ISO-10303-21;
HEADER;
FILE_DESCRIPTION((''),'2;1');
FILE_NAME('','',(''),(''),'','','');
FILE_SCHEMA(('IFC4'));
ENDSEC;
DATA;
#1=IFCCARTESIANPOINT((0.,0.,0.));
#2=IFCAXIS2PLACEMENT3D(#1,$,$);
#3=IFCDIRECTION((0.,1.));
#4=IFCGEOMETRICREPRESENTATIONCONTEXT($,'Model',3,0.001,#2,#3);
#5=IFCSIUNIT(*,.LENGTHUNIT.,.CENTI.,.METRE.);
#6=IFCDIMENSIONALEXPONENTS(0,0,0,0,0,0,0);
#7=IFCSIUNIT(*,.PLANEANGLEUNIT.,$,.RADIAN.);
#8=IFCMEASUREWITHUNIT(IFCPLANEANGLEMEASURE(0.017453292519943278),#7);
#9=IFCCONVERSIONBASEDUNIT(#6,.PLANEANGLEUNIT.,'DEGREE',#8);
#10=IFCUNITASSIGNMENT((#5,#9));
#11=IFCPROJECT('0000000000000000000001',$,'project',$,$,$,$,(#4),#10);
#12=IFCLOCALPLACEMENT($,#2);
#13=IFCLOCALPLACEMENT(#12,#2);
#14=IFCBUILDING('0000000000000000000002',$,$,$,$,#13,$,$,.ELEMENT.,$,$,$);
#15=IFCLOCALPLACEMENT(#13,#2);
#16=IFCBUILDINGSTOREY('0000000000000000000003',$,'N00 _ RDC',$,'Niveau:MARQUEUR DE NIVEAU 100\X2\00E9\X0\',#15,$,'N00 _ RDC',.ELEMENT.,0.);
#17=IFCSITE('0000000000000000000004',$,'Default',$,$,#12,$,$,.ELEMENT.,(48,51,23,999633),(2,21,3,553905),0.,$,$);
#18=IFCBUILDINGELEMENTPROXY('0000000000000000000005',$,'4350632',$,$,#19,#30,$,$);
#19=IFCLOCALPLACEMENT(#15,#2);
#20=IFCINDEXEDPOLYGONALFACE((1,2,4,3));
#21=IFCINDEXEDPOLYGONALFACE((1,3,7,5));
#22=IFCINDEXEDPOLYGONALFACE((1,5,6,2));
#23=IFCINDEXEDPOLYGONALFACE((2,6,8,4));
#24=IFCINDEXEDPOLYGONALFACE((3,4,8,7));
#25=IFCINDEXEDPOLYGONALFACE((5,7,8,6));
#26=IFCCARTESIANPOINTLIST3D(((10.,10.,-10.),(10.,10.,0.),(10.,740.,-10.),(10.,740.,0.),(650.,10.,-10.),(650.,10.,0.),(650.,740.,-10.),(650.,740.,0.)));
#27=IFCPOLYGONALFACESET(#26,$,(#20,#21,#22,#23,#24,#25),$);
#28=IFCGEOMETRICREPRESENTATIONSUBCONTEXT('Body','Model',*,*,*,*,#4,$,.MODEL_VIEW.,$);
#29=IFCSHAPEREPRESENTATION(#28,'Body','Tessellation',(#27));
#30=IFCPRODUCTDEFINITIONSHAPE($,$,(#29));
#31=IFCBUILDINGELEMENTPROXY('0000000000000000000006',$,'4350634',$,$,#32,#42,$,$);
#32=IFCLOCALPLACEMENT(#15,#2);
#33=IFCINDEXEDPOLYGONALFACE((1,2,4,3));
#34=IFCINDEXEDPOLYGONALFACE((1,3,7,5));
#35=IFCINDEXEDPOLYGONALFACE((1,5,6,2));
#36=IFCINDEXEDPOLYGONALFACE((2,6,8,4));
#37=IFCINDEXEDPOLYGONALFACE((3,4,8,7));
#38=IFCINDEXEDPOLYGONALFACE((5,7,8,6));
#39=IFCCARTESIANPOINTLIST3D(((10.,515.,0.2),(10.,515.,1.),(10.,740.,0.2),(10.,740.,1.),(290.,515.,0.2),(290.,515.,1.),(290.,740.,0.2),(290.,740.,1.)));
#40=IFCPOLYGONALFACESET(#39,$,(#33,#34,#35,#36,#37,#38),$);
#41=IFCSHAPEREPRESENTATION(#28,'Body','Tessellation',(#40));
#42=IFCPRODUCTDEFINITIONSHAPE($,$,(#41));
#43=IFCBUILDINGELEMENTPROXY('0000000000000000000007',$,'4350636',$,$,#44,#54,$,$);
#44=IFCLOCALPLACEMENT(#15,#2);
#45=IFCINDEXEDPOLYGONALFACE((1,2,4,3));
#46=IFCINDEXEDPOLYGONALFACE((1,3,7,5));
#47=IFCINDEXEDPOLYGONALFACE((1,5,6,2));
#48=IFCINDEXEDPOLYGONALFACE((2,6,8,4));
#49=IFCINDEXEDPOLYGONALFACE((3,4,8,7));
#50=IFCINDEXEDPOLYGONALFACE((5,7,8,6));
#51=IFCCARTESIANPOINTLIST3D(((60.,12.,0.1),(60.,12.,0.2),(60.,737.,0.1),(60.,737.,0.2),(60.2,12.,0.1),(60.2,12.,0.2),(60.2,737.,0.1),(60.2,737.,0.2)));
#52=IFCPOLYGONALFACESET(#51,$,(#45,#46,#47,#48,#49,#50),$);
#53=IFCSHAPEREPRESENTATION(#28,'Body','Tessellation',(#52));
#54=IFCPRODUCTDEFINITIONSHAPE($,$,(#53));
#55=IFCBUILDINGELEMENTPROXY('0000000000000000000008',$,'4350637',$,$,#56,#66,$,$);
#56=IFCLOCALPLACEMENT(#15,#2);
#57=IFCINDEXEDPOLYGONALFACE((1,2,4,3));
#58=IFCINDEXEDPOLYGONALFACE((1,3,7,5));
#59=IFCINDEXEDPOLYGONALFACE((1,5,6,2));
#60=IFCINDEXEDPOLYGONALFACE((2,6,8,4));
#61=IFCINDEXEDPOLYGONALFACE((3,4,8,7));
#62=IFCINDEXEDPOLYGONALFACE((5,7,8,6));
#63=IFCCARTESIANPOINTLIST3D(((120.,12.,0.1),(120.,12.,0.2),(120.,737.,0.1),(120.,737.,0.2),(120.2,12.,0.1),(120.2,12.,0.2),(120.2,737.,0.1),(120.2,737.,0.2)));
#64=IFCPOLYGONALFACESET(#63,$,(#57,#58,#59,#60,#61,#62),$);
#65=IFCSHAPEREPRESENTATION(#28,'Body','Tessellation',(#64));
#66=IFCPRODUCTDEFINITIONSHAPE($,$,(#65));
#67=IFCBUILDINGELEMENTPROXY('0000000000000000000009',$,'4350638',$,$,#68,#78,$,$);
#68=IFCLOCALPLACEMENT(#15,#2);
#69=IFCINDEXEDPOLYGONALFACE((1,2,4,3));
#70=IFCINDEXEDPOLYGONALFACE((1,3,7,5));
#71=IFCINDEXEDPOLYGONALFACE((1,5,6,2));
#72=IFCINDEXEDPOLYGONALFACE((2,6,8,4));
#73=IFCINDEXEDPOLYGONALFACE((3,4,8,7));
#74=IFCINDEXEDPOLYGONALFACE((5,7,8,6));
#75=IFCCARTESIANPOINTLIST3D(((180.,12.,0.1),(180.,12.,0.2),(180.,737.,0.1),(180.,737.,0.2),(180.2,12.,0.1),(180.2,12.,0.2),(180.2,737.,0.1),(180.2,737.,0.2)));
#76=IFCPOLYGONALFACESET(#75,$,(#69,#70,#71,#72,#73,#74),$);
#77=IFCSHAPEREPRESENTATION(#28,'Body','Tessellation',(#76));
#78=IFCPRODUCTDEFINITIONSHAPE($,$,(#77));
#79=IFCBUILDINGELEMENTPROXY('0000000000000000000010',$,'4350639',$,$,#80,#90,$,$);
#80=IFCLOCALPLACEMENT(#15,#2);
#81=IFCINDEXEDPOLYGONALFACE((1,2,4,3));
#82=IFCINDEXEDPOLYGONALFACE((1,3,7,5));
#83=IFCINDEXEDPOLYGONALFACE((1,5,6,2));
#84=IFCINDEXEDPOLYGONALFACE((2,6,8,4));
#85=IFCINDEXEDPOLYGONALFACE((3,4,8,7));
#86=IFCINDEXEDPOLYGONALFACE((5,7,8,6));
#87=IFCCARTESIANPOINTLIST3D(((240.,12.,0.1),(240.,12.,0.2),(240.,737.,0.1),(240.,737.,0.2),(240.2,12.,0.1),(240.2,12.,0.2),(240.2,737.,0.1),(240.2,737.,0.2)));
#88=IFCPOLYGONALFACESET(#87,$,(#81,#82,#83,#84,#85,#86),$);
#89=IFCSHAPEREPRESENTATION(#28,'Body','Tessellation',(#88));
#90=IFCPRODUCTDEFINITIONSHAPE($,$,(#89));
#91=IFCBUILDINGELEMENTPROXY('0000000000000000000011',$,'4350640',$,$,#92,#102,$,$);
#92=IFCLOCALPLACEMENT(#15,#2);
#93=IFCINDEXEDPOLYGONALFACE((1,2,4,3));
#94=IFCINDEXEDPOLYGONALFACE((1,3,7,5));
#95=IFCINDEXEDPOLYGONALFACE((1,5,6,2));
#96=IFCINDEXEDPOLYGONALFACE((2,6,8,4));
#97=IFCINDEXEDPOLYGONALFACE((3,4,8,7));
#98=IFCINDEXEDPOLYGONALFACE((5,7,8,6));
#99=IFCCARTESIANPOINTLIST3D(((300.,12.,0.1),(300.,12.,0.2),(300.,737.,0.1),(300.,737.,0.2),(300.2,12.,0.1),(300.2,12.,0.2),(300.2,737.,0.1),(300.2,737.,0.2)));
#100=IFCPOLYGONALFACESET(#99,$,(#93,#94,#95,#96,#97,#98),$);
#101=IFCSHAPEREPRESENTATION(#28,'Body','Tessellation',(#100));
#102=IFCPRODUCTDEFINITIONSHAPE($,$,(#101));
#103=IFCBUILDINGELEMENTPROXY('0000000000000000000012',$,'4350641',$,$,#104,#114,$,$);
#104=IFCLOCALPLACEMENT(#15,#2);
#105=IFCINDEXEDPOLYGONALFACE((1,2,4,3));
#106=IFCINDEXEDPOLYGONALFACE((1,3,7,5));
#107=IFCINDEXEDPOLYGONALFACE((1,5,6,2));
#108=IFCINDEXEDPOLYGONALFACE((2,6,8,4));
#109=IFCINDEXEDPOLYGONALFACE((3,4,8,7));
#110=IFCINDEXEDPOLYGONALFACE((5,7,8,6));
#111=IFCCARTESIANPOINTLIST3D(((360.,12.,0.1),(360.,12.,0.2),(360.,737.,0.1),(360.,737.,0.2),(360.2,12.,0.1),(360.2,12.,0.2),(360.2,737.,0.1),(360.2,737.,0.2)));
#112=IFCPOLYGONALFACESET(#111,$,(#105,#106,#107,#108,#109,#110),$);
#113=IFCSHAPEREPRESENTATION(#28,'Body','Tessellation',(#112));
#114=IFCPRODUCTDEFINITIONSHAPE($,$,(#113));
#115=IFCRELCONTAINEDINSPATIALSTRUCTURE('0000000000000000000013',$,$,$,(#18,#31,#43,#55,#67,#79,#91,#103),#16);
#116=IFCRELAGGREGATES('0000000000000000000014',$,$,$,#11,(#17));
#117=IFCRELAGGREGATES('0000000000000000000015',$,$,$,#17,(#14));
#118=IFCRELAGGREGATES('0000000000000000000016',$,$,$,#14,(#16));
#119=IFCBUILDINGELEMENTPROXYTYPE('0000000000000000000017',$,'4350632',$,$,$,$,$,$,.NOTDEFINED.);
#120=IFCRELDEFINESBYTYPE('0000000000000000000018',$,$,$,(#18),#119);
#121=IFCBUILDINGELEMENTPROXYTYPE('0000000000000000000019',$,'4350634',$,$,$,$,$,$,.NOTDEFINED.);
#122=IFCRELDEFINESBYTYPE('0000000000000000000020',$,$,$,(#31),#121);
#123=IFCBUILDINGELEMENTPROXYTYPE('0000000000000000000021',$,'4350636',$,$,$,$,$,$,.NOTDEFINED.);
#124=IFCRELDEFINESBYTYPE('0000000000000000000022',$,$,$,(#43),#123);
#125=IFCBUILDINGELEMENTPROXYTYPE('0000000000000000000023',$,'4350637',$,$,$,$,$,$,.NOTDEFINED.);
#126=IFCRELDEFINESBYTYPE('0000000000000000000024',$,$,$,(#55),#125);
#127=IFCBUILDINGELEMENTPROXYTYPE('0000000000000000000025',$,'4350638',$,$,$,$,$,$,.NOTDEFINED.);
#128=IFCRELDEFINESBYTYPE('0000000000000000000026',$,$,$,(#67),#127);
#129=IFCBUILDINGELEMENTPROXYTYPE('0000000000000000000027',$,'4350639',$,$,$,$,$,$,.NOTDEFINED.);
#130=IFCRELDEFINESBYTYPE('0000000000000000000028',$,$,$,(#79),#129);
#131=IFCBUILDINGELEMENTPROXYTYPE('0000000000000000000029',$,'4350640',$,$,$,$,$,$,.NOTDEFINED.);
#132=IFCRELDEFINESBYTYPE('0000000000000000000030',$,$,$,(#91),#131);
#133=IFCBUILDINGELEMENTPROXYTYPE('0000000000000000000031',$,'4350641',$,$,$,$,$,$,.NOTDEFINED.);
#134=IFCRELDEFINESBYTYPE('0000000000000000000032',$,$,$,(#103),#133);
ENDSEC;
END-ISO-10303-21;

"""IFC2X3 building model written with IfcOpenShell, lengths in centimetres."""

from ifc_helpers import new_model, entity, si_unit, converted_unit, direction, frame, frame_2d, origin, origin_2d_with_axis, place, context, subcontext, project, spatial, rectangle, extrude, type_object, element, save


model = new_model("IFC2X3")

# Units and contexts
model_context = context("Model", 3, precision=0.001, world=origin(), true_north=direction((0.0, 1.0)))
body_context = subcontext(model_context, "Body", "Model", "MODEL_VIEW")
ifc_project = project(units=[si_unit("LENGTHUNIT", "METRE", prefix="CENTI"), converted_unit("PLANEANGLEUNIT", "DEGREE", entity("IfcPlaneAngleMeasure", 0.017453292519943278), si_unit("PLANEANGLEUNIT", "RADIAN"), dimensions=[0, 0, 0, 0, 0, 0, 0])], contexts=[model_context])

# Site, building, storey
site_placement = place(None, origin())
site = spatial("IfcSite", under=ifc_project, at=site_placement, Name="Default", CompositionType="ELEMENT", RefLatitude=(48, 51, 23, 999633), RefLongitude=(2, 21, 3, 553905), RefElevation=0.0)
building_placement = place(site_placement, origin())
building = spatial("IfcBuilding", under=site, at=building_placement, CompositionType="ELEMENT")
storey_placement = place(building_placement, origin())
storey = spatial("IfcBuildingStorey", under=building, at=storey_placement, Name="N00 _ RDC", ObjectType="Niveau:MARQUEUR DE NIVEAU 100é", LongName="N00 _ RDC", CompositionType="ELEMENT", Elevation=0.0)

# Building element proxies
building_element_proxy_type_1 = type_object("IfcBuildingElementProxyType", Name="4350632", PredefinedType="NOTDEFINED")
proxy_1_placement = place(storey_placement, origin())
element("IfcBuildingElementProxy", 1, at=proxy_1_placement, inside=storey, type_object=building_element_proxy_type_1, Name="4350632", context=body_context, shape_type="SweptSolid", body=[
    extrude(rectangle(XDim=640.0, YDim=730.0, at=origin_2d_with_axis()), frame((330.0, 375.0, -10.0)), (0.0, 0.0, 1.0), 10.0),
])
building_element_proxy_type_2 = type_object("IfcBuildingElementProxyType", Name="4350634", PredefinedType="NOTDEFINED")
proxy_2_placement = place(storey_placement, origin())
element("IfcBuildingElementProxy", 2, at=proxy_2_placement, inside=storey, type_object=building_element_proxy_type_2, Name="4350634", context=body_context, shape_type="SweptSolid", body=[
    extrude(rectangle(XDim=280.0, YDim=225.0, at=frame_2d((0.0, 0.0), x_axis=(1.0, 0.0))), frame((150.0, 627.5, 0.2)), (0.0, 0.0, 1.0), 0.8),
])
building_element_proxy_type_3 = type_object("IfcBuildingElementProxyType", Name="4350636", PredefinedType="NOTDEFINED")
proxy_3_placement = place(storey_placement, origin())
element("IfcBuildingElementProxy", 3, at=proxy_3_placement, inside=storey, type_object=building_element_proxy_type_3, Name="4350636", context=body_context, shape_type="SweptSolid", body=[
    extrude(rectangle(XDim=0.2, YDim=725.0, at=frame_2d((0.0, 0.0), x_axis=(1.0, 0.0))), frame((60.1, 374.5, 0.1)), (0.0, 0.0, 1.0), 0.1),
])
building_element_proxy_type_4 = type_object("IfcBuildingElementProxyType", Name="4350637", PredefinedType="NOTDEFINED")
proxy_4_placement = place(storey_placement, origin())
element("IfcBuildingElementProxy", 4, at=proxy_4_placement, inside=storey, type_object=building_element_proxy_type_4, Name="4350637", context=body_context, shape_type="SweptSolid", body=[
    extrude(rectangle(XDim=0.2, YDim=725.0, at=frame_2d((0.0, 0.0), x_axis=(1.0, 0.0))), frame((120.1, 374.5, 0.1)), (0.0, 0.0, 1.0), 0.1),
])
building_element_proxy_type_5 = type_object("IfcBuildingElementProxyType", Name="4350638", PredefinedType="NOTDEFINED")
proxy_5_placement = place(storey_placement, origin())
element("IfcBuildingElementProxy", 5, at=proxy_5_placement, inside=storey, type_object=building_element_proxy_type_5, Name="4350638", context=body_context, shape_type="SweptSolid", body=[
    extrude(rectangle(XDim=0.2, YDim=725.0, at=origin_2d_with_axis()), frame((180.1, 374.5, 0.1)), (0.0, 0.0, 1.0), 0.1),
])
building_element_proxy_type_6 = type_object("IfcBuildingElementProxyType", Name="4350639", PredefinedType="NOTDEFINED")
proxy_6_placement = place(storey_placement, origin())
element("IfcBuildingElementProxy", 6, at=proxy_6_placement, inside=storey, type_object=building_element_proxy_type_6, Name="4350639", context=body_context, shape_type="SweptSolid", body=[
    extrude(rectangle(XDim=0.2, YDim=725.0, at=frame_2d((0.0, 0.0), x_axis=(1.0, 0.0))), frame((240.1, 374.5, 0.1)), (0.0, 0.0, 1.0), 0.1),
])
building_element_proxy_type_7 = type_object("IfcBuildingElementProxyType", Name="4350640", PredefinedType="NOTDEFINED")
proxy_7_placement = place(storey_placement, origin())
element("IfcBuildingElementProxy", 7, at=proxy_7_placement, inside=storey, type_object=building_element_proxy_type_7, Name="4350640", context=body_context, shape_type="SweptSolid", body=[
    extrude(rectangle(XDim=0.2, YDim=725.0, at=origin_2d_with_axis()), frame((300.1, 374.5, 0.1)), (0.0, 0.0, 1.0), 0.1),
])
building_element_proxy_type_8 = type_object("IfcBuildingElementProxyType", Name="4350641", PredefinedType="NOTDEFINED")
proxy_8_placement = place(storey_placement, origin())
element("IfcBuildingElementProxy", 8, at=proxy_8_placement, inside=storey, type_object=building_element_proxy_type_8, Name="4350641", context=body_context, shape_type="SweptSolid", body=[
    extrude(rectangle(XDim=0.2, YDim=725.0, at=origin_2d_with_axis()), frame((360.1, 374.5, 0.1)), (0.0, 0.0, 1.0), 0.1),
])

save(model, "model.ifc")
